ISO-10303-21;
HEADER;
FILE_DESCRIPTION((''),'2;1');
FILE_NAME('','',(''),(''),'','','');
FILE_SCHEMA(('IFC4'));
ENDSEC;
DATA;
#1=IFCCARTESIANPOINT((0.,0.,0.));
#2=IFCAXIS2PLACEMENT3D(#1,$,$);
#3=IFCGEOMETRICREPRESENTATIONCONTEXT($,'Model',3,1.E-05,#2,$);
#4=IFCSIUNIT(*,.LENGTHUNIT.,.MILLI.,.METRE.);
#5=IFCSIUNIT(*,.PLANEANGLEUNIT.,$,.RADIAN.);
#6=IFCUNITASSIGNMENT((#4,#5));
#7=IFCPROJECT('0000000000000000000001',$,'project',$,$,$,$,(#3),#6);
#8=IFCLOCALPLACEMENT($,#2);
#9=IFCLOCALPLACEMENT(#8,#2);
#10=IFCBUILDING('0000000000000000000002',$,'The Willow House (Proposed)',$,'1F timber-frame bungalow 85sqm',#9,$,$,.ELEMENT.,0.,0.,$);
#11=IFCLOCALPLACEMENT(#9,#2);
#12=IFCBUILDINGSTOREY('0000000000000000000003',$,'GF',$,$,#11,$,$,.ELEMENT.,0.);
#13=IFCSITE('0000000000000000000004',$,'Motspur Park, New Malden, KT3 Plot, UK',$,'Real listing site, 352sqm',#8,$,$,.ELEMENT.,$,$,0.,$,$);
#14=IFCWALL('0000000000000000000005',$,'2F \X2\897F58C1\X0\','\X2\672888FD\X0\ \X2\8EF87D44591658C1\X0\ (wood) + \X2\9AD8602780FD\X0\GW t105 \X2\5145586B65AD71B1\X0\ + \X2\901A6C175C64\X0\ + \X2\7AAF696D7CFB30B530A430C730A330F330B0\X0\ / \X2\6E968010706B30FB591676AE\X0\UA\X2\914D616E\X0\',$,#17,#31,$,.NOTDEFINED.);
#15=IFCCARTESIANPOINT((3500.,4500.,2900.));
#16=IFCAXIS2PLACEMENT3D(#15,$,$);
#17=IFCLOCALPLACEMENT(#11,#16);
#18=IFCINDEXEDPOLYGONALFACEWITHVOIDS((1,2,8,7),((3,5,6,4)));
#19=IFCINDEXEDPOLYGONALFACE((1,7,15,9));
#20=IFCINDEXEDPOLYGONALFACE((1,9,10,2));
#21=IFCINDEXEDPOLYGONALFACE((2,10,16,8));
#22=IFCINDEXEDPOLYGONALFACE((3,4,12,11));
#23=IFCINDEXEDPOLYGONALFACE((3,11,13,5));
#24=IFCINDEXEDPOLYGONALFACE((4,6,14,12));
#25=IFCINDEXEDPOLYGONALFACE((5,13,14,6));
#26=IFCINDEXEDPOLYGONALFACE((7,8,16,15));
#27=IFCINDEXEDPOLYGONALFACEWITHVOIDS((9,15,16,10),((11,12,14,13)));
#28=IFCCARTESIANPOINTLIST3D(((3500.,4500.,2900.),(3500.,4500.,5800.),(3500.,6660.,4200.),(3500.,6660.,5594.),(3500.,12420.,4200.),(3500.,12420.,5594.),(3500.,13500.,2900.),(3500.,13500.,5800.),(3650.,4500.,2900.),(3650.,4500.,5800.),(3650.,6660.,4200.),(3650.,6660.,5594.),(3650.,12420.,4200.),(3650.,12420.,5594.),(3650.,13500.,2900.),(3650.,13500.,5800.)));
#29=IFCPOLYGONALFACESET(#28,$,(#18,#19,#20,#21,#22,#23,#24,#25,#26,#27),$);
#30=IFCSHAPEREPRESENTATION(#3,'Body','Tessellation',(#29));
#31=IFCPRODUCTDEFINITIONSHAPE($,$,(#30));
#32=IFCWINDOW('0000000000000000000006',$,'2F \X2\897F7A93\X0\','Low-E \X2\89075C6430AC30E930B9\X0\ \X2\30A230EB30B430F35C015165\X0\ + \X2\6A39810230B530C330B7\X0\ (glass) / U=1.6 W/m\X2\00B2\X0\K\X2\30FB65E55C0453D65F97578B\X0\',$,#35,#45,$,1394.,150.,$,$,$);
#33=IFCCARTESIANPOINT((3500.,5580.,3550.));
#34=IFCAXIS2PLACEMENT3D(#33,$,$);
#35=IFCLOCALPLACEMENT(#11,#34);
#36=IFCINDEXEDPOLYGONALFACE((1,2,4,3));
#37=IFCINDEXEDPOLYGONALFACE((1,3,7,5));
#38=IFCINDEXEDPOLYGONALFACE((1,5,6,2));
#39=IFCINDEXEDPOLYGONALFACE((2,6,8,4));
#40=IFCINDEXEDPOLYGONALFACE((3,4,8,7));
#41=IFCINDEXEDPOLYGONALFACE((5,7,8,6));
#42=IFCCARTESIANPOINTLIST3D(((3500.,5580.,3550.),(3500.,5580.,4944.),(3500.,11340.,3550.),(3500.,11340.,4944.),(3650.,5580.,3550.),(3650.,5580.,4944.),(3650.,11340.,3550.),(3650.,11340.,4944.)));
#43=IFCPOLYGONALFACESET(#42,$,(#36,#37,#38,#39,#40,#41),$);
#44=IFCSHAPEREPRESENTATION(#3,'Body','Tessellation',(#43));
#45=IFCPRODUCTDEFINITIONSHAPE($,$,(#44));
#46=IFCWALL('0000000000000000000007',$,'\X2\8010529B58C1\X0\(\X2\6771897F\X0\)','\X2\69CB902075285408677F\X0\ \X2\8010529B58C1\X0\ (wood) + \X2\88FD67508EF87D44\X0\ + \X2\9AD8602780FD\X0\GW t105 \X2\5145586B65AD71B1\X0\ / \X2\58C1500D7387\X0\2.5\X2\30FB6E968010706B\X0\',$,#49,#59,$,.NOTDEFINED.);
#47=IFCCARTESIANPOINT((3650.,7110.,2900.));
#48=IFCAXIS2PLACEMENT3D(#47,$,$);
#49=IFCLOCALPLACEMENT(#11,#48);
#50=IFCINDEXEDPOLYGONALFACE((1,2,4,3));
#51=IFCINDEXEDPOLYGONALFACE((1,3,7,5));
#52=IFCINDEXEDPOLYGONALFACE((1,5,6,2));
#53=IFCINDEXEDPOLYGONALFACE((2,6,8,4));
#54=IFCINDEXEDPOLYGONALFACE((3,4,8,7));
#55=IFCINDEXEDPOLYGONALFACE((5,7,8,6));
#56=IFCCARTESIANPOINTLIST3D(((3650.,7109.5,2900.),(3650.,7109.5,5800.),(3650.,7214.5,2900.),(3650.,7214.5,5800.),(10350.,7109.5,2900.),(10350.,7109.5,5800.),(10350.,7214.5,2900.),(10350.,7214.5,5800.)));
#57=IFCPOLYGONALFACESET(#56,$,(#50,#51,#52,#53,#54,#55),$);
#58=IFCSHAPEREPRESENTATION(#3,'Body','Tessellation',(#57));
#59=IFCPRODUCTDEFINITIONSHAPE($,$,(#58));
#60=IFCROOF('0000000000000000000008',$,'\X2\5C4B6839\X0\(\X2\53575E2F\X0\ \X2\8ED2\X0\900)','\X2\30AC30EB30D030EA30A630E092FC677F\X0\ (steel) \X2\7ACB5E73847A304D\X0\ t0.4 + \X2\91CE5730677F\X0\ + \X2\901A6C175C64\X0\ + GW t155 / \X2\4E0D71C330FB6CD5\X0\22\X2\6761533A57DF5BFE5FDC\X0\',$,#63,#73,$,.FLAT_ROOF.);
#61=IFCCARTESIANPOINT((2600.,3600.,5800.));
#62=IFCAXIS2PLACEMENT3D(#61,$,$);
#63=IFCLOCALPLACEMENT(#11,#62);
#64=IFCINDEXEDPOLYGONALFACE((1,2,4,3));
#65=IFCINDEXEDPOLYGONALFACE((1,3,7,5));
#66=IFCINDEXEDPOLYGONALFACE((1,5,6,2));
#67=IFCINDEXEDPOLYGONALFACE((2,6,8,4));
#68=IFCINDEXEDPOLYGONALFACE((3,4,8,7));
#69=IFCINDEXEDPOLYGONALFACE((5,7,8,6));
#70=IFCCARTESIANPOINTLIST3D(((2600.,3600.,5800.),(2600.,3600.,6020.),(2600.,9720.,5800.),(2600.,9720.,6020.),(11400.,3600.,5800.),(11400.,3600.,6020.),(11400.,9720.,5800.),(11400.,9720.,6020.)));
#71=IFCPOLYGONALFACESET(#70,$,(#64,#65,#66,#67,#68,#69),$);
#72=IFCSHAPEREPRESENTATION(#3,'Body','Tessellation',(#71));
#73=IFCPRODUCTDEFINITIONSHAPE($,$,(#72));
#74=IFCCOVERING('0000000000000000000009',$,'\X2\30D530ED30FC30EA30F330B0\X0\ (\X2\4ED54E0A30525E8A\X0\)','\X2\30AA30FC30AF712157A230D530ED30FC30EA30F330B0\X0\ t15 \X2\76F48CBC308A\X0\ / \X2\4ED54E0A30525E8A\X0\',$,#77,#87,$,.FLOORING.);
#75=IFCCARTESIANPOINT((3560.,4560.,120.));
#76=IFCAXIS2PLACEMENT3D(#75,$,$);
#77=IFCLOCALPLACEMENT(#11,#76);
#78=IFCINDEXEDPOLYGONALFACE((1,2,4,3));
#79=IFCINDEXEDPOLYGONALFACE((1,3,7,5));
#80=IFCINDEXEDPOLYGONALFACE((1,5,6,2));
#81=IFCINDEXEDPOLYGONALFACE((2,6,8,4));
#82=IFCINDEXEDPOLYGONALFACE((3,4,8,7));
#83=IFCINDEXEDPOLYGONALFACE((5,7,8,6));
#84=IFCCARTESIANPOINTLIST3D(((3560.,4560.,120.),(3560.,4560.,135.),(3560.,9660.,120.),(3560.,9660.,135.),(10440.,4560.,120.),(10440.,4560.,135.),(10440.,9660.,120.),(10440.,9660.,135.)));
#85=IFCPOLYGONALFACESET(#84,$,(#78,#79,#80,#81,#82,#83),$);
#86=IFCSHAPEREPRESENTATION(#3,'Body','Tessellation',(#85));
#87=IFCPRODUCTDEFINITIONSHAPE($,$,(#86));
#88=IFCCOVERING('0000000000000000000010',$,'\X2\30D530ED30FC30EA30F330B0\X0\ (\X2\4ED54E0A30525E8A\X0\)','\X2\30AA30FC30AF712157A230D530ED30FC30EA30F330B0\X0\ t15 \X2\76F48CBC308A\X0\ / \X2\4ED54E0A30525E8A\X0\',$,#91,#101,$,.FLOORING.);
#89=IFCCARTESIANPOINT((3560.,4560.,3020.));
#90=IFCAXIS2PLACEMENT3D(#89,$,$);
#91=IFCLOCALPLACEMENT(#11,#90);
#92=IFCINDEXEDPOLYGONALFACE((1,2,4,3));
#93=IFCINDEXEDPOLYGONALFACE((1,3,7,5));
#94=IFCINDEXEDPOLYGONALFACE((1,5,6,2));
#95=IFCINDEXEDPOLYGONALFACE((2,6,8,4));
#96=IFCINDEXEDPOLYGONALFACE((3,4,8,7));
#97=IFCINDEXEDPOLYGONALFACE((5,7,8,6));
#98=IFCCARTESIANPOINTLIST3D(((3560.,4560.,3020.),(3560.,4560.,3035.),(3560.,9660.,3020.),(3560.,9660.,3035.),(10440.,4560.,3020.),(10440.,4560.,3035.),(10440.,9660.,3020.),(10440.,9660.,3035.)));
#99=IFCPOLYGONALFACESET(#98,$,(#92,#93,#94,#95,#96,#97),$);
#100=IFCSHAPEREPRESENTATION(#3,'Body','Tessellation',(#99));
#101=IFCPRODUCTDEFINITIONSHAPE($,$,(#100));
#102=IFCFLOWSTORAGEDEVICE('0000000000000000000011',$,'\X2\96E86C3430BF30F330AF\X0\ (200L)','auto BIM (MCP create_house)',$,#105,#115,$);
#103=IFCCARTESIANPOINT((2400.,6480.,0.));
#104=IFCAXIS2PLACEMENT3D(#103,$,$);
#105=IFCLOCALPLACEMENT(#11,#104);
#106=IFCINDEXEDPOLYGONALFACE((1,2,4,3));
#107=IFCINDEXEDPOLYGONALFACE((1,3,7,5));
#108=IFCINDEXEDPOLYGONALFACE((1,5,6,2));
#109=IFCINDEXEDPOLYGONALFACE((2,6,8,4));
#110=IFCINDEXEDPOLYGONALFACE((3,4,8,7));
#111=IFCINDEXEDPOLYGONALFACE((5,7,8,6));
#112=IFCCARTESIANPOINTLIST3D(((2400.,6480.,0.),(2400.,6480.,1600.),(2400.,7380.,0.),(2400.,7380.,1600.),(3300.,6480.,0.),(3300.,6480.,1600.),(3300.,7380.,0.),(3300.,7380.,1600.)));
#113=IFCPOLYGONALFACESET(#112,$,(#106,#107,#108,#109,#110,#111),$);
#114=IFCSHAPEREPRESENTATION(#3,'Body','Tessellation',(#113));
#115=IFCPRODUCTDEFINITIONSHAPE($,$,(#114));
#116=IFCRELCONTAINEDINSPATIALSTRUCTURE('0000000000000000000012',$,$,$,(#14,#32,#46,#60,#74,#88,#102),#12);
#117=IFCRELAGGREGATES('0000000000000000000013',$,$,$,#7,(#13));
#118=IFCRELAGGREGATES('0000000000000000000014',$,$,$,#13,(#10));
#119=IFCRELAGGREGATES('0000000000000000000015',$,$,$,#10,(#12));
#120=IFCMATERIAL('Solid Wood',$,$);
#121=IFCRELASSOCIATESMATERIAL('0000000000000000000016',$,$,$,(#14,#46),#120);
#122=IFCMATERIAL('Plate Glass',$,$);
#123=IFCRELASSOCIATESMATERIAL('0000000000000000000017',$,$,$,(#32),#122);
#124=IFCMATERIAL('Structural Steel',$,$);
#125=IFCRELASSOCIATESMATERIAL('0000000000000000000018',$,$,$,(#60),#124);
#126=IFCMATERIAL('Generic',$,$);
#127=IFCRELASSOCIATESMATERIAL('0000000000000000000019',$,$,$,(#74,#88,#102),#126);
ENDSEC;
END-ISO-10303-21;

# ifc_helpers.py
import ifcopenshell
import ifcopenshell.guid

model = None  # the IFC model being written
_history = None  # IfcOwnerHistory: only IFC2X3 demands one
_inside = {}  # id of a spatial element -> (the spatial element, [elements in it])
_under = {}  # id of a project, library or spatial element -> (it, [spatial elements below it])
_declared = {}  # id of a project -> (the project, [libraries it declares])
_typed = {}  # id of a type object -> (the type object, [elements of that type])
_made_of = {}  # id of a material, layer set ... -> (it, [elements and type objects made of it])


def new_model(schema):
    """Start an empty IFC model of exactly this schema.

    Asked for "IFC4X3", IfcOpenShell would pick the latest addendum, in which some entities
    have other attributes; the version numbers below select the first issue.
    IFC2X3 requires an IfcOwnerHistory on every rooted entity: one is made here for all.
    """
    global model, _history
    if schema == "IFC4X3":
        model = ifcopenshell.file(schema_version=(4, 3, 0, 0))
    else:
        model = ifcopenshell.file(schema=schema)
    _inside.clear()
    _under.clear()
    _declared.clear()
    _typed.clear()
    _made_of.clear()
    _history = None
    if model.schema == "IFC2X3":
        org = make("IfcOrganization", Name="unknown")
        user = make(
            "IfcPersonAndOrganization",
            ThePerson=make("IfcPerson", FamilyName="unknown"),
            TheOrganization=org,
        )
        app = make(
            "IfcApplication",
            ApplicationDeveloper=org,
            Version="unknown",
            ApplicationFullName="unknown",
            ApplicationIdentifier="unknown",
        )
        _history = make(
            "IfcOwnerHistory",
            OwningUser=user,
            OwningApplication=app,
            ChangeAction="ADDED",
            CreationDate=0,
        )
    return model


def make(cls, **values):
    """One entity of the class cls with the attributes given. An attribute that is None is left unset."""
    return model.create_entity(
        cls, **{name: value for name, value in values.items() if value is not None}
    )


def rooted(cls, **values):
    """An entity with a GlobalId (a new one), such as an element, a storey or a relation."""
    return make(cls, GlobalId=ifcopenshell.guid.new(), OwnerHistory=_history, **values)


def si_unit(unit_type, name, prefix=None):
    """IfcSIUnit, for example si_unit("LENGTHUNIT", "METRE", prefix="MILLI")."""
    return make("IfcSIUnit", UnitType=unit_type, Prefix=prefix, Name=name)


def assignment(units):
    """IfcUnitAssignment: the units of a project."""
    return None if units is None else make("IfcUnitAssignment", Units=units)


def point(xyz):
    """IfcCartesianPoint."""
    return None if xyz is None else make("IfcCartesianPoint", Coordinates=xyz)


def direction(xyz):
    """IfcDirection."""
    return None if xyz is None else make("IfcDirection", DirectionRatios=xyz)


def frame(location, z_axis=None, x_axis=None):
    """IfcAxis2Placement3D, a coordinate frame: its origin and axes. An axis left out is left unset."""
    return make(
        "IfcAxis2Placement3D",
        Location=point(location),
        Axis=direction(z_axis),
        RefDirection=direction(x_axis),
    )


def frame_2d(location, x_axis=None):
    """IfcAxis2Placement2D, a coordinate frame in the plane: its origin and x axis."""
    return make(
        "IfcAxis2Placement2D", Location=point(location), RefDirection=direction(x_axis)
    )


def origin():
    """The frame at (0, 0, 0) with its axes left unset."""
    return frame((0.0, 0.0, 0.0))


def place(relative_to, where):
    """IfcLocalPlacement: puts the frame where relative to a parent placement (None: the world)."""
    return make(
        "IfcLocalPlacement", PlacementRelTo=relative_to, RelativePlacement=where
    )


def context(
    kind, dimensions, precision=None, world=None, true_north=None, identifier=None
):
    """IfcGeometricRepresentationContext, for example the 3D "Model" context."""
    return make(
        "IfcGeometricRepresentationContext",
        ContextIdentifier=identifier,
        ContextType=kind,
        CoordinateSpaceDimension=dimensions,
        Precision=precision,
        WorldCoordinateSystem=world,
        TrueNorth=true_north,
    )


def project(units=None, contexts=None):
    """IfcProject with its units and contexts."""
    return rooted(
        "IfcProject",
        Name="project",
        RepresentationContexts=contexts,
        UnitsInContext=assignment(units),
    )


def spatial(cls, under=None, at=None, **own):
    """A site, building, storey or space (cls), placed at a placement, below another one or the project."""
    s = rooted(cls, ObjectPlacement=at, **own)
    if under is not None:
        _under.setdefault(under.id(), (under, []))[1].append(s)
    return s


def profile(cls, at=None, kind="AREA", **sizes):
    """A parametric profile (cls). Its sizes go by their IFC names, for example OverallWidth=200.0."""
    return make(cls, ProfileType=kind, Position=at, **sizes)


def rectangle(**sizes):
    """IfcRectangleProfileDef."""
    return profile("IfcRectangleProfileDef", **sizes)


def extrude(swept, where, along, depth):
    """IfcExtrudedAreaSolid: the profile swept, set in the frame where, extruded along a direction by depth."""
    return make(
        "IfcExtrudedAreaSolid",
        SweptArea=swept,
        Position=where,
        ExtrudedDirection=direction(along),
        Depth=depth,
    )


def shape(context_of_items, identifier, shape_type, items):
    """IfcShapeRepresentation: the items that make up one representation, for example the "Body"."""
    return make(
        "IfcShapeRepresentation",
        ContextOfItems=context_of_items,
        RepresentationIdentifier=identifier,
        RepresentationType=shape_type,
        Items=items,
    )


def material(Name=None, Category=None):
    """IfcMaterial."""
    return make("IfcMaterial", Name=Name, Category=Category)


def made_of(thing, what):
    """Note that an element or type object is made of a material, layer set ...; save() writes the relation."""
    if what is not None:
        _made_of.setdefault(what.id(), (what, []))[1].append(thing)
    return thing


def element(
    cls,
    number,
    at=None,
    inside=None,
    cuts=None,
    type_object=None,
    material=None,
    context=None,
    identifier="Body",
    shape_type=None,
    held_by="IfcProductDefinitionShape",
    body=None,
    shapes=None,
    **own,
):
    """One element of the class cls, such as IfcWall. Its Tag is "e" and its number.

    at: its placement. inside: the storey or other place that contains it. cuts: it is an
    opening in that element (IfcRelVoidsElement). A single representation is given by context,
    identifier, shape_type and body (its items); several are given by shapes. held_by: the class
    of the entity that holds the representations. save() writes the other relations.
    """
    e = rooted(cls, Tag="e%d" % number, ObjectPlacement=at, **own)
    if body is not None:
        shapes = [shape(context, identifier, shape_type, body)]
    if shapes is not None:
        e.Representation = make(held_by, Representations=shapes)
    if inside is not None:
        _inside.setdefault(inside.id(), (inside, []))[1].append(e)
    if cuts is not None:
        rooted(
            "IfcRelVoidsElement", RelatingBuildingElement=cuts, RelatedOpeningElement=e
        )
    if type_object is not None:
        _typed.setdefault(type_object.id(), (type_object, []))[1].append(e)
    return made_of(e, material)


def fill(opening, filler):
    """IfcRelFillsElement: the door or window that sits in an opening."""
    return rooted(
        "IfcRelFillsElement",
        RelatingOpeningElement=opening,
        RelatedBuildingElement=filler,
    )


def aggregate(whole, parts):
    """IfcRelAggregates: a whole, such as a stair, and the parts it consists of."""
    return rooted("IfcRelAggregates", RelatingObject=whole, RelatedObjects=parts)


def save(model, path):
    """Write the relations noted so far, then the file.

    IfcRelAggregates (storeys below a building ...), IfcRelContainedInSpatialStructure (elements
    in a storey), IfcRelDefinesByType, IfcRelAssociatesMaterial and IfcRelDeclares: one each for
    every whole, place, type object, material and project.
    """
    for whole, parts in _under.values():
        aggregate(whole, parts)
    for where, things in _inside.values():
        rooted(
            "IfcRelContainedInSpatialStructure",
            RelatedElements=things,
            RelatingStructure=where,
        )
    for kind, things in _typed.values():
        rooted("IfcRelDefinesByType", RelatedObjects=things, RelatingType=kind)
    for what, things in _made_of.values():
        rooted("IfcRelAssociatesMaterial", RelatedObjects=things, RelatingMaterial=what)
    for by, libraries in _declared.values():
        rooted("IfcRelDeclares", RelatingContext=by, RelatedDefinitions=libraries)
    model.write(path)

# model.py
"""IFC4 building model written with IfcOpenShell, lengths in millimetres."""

from ifc_helpers import new_model, si_unit, frame, frame_2d, origin, place, context, project, spatial, rectangle, extrude, material, element, fill, save


model = new_model("IFC4")

# Units and contexts
model_context = context("Model", 3, precision=1e-05, world=origin())
ifc_project = project(units=[si_unit("LENGTHUNIT", "METRE", prefix="MILLI"), si_unit("PLANEANGLEUNIT", "RADIAN")], contexts=[model_context])

# Site, building, storey
site_placement = place(None, origin())
site = spatial("IfcSite", under=ifc_project, at=site_placement, Name="Motspur Park, New Malden, KT3 Plot, UK", ObjectType="Real listing site, 352sqm", CompositionType="ELEMENT", RefElevation=0.0)
building_placement = place(site_placement, origin())
building = spatial("IfcBuilding", under=site, at=building_placement, Name="The Willow House (Proposed)", ObjectType="1F timber-frame bungalow 85sqm", CompositionType="ELEMENT", ElevationOfRefHeight=0.0, ElevationOfTerrain=0.0)
storey_placement = place(building_placement, origin())
storey = spatial("IfcBuildingStorey", under=building, at=storey_placement, Name="GF", CompositionType="ELEMENT", Elevation=0.0)

# Shared definitions
ifc_material_1 = material(Name="Solid Wood")
ifc_material_2 = material(Name="Generic")

# Shared definitions
ifc_material_3 = material(Name="Plate Glass")

# Wall, opening, window
wall_1_placement = place(storey_placement, frame((3500.0, 4500.0, 2900.0)))
wall_1 = element("IfcWall", 1, at=wall_1_placement, inside=storey, material=ifc_material_1, Name="2F 西壁", Description="木製 軸組外壁 (wood) + 高性能GW t105 充填断熱 + 通気層 + 窯業系サイディング / 準耐火・外皮UA配慮", PredefinedType="NOTDEFINED", context=model_context, shape_type="SweptSolid", body=[
    extrude(rectangle(XDim=150.0, YDim=9000.0, at=frame_2d((75.0, 4500.0))), frame((3500.0, 4500.0, 2900.0)), (0.0, 0.0, 1.0), 2900.0),
])
opening_1_placement = place(storey_placement, frame((3500.0, 5580.0, 3550.0)))
opening_1 = element("IfcOpeningElement", 2, at=opening_1_placement, cuts=wall_1, PredefinedType="NOTDEFINED", context=model_context, shape_type="SweptSolid", body=[
    extrude(rectangle(XDim=150.0, YDim=5760.0, at=frame_2d((75.0, 2880.0))), frame((3500.0, 5580.0, 3550.0)), (0.0, 0.0, 1.0), 1394.0),
])
window_1_placement = place(storey_placement, frame((3500.0, 5580.0, 3550.0)))
window_1 = element("IfcWindow", 3, at=window_1_placement, inside=storey, material=ifc_material_3, Name="2F 西窓", Description="Low-E 複層ガラス アルゴン封入 + 樹脂サッシ (glass) / U=1.6 W/m²K・日射取得型", OverallHeight=1394.0, OverallWidth=150.0, context=model_context, shape_type="SweptSolid", body=[
    extrude(rectangle(XDim=150.0, YDim=5760.0, at=frame_2d((75.0, 2880.0))), frame((3500.0, 5580.0, 3550.0)), (0.0, 0.0, 1.0), 1394.0),
])
fill(opening_1, window_1)

# Wall
wall_2_placement = place(storey_placement, frame((3650.0, 7110.0, 2900.0)))
element("IfcWall", 4, at=wall_2_placement, inside=storey, material=ifc_material_1, Name="耐力壁(東西)", Description="構造用合板 耐力壁 (wood) + 製材軸組 + 高性能GW t105 充填断熱 / 壁倍率2.5・準耐火", PredefinedType="NOTDEFINED", context=model_context, shape_type="SweptSolid", body=[
    extrude(rectangle(XDim=6700.0, YDim=105.0, at=frame_2d((3350.0, 52.0))), frame((3650.0, 7110.0, 2900.0)), (0.0, 0.0, 1.0), 2900.0),
])

# Roof
ifc_material_4 = material(Name="Structural Steel")
for number, where, name in (
    (5, (2600.0, 3600.0, 5800.0), "屋根(南帯 軒900)"),
):
    element("IfcRoof", number, at=place(storey_placement, frame(where)), inside=storey, material=ifc_material_4, Name=name, Description="ガルバリウム鋼板 (steel) 立平葺き t0.4 + 野地板 + 通気層 + GW t155 / 不燃・法22条区域対応", PredefinedType="FLAT_ROOF", context=model_context, shape_type="SweptSolid", body=[
        extrude(rectangle(XDim=8800.0, YDim=6120.0, at=frame_2d((4400.0, 3060.0))), frame((2600.0, 3600.0, 5800.0)), (0.0, 0.0, 1.0), 220.0),
    ])

# Coverings
covering_1_placement = place(storey_placement, frame((3560.0, 4560.0, 120.0)))
element("IfcCovering", 6, at=covering_1_placement, inside=storey, material=ifc_material_2, Name="フローリング (仕上げ床)", Description="オーク無垢フローリング t15 直貼り / 仕上げ床", PredefinedType="FLOORING", context=model_context, shape_type="SweptSolid", body=[
    extrude(rectangle(XDim=6880.0, YDim=5100.0, at=frame_2d((3440.0, 2550.0))), frame((3560.0, 4560.0, 120.0)), (0.0, 0.0, 1.0), 15.0),
])
covering_2_placement = place(storey_placement, frame((3560.0, 4560.0, 3020.0)))
element("IfcCovering", 7, at=covering_2_placement, inside=storey, material=ifc_material_2, Name="フローリング (仕上げ床)", Description="オーク無垢フローリング t15 直貼り / 仕上げ床", PredefinedType="FLOORING", context=model_context, shape_type="SweptSolid", body=[
    extrude(rectangle(XDim=6880.0, YDim=5100.0, at=frame_2d((3440.0, 2550.0))), frame((3560.0, 4560.0, 3020.0)), (0.0, 0.0, 1.0), 15.0),
])

# Flow storage device
flow_storage_device_placement = place(storey_placement, frame((2400.0, 6480.0, 0.0)))
element("IfcFlowStorageDevice", 8, at=flow_storage_device_placement, inside=storey, material=ifc_material_2, Name="雨水タンク (200L)", Description="auto BIM (MCP create_house)", context=model_context, shape_type="SweptSolid", body=[
    extrude(rectangle(XDim=900.0, YDim=900.0, at=frame_2d((450.0, 450.0))), frame((2400.0, 6480.0, 0.0)), (0.0, 0.0, 1.0), 1600.0),
])

save(model, "model.ifc")
